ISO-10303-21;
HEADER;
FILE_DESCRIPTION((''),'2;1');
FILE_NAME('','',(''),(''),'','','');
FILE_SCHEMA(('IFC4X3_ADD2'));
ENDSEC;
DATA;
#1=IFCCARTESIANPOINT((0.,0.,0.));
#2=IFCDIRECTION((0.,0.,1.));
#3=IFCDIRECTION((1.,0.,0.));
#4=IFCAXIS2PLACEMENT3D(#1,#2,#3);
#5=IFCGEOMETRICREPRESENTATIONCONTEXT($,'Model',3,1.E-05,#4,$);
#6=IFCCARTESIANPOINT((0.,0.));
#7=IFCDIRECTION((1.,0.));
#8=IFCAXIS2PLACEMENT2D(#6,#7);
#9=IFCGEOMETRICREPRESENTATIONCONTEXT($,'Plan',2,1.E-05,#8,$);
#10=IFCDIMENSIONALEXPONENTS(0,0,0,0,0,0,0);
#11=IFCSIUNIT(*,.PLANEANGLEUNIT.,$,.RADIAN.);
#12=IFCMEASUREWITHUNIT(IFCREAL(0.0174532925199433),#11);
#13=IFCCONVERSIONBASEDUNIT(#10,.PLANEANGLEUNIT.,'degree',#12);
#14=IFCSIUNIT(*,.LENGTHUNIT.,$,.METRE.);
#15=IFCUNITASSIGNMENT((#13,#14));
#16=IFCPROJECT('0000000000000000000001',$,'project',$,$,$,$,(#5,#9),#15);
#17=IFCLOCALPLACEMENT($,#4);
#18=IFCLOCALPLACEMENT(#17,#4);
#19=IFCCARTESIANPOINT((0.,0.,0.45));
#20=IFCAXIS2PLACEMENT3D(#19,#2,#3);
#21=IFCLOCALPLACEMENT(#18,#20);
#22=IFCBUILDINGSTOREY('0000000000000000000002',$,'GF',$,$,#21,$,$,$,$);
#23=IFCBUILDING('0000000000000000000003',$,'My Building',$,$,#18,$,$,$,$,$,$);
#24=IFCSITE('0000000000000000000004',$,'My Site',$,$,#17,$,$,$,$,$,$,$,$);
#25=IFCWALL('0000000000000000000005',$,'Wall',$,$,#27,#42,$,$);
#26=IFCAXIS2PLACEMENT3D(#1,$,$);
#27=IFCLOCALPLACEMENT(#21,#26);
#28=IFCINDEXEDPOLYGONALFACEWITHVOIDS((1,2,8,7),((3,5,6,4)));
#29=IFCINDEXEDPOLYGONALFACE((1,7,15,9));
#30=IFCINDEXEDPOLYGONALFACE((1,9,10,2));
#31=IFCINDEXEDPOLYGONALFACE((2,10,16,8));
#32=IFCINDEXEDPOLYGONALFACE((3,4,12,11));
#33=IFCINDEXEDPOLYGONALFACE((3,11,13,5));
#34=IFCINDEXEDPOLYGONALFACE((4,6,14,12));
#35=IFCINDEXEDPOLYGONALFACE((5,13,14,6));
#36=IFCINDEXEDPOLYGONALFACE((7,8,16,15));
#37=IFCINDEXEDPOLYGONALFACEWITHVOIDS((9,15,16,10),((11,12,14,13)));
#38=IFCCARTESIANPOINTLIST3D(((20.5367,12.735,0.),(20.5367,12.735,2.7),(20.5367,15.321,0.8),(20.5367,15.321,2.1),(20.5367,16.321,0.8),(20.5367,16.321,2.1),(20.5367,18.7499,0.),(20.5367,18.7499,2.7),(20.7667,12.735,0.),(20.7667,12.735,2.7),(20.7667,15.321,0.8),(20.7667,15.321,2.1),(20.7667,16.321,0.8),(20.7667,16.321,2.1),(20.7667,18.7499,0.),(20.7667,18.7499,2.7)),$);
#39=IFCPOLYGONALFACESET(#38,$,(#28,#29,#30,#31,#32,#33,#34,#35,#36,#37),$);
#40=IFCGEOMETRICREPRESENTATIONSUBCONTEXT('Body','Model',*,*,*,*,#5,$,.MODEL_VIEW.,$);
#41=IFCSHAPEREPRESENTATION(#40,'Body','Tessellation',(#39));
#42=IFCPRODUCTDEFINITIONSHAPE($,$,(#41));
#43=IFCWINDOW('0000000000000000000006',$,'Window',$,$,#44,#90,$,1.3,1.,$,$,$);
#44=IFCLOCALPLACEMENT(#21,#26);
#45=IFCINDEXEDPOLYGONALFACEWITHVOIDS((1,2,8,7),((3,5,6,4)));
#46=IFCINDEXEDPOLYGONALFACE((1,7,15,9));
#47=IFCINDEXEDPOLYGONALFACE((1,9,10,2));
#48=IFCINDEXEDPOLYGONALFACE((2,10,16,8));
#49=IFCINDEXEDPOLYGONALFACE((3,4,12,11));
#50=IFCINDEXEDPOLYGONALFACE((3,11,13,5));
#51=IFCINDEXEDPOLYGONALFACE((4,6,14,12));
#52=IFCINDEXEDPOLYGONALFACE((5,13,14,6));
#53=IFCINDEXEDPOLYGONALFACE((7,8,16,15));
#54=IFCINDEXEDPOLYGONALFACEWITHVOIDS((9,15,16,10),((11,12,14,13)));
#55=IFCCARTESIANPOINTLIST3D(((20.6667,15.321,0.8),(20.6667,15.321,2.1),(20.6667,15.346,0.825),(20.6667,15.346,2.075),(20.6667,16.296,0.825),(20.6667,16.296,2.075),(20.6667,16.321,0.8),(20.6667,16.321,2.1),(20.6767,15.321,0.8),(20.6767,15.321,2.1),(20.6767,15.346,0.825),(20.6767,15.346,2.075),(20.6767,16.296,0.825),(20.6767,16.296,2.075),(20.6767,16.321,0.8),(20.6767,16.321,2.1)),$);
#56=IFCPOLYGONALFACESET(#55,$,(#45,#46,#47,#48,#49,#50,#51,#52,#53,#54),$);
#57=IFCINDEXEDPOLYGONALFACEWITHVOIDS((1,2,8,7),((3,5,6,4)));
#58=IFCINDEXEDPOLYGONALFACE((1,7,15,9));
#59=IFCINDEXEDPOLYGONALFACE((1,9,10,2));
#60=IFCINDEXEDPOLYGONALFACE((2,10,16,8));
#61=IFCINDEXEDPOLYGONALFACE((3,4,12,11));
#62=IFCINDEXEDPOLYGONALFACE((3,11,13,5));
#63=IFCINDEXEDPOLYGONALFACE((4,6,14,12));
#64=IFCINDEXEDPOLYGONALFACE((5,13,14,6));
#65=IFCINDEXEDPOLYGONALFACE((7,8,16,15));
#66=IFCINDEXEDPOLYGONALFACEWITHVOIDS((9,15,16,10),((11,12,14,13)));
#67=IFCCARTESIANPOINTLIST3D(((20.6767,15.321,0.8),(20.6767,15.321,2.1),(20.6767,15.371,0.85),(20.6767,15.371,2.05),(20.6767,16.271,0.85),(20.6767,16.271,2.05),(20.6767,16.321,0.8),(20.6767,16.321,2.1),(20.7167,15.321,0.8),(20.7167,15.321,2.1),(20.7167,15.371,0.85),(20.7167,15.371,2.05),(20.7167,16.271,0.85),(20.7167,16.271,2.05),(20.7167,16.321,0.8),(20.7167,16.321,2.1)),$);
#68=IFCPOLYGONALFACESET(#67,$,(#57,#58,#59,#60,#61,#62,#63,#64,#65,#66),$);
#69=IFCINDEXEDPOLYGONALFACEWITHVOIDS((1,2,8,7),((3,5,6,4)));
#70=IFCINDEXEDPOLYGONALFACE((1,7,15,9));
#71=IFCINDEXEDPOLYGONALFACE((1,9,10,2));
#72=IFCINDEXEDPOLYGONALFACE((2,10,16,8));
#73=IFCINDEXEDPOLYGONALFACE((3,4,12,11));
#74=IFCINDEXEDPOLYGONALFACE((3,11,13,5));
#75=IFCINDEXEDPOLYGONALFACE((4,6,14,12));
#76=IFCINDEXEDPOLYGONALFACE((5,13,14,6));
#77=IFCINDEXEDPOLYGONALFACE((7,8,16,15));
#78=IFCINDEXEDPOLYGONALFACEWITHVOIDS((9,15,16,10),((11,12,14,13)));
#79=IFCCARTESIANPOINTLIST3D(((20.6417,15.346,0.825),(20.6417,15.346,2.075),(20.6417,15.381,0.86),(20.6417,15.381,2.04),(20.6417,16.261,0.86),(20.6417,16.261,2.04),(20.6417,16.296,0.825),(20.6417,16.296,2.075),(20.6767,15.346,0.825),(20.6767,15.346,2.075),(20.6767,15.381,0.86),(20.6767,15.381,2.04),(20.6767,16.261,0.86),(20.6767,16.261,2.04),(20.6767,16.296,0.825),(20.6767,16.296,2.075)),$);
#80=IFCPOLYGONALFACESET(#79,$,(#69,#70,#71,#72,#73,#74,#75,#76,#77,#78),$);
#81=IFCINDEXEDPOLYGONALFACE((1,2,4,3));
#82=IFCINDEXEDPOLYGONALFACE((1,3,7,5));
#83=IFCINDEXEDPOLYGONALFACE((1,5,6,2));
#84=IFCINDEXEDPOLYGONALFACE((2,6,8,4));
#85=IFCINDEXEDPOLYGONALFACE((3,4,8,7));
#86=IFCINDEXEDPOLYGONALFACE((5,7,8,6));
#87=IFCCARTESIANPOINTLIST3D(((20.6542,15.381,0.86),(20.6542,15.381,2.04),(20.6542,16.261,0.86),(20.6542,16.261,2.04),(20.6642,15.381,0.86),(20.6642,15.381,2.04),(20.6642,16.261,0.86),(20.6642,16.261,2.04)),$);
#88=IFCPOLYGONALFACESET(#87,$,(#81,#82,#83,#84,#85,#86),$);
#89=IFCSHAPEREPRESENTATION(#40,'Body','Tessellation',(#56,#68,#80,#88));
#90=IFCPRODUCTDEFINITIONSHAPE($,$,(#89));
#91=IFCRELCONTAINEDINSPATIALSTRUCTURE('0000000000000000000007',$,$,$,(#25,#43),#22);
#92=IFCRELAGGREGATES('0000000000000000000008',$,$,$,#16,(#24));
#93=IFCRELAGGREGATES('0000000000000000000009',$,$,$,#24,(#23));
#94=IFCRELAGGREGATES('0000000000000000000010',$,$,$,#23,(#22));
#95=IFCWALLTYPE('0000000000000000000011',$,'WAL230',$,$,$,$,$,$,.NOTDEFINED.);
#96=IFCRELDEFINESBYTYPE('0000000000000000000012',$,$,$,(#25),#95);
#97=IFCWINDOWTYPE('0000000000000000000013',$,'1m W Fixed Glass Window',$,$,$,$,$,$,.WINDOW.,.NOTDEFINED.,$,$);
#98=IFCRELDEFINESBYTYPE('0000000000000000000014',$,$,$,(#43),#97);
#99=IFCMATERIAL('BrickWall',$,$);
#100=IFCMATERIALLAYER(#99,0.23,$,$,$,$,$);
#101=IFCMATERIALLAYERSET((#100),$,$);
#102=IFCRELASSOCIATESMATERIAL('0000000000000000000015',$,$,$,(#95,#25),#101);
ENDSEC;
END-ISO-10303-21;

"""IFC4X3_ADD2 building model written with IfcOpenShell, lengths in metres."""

from ifc_helpers import new_model, entity, si_unit, converted_unit, frame, origin_with_axes, origin_2d_with_axis, place, context, subcontext, project, spatial, line, indexed_curve, outline, extrude, shape, source, transform, mapped, material, layer, layer_set, layer_usage, type_object, type_shapes, element, fill, save


model = new_model("IFC4X3_ADD2")

# Units and contexts
model_context = context("Model", 3, precision=1e-05, world=origin_with_axes())
plan_context = context("Plan", 2, precision=1e-05, world=origin_2d_with_axis())
body_context_1 = subcontext(model_context, "Body", "Model", "MODEL_VIEW")
body_context_2 = subcontext(plan_context, "Body", "Plan", "PLAN_VIEW")
ifc_project = project(units=[converted_unit("PLANEANGLEUNIT", "degree", entity("IfcReal", 0.0174532925199433), si_unit("PLANEANGLEUNIT", "RADIAN"), dimensions=[0, 0, 0, 0, 0, 0, 0]), si_unit("LENGTHUNIT", "METRE")], contexts=[model_context, plan_context])

# Site, building, storey
site_placement = place(None, origin_with_axes())
site = spatial("IfcSite", under=ifc_project, at=site_placement, Name="My Site")
building_placement = place(site_placement, origin_with_axes())
building = spatial("IfcBuilding", under=site, at=building_placement, Name="My Building")
storey_placement = place(building_placement, frame((0.0, 0.0, 0.45), z_axis=(0.0, 0.0, 1.0), x_axis=(1.0, 0.0, 0.0)))
storey = spatial("IfcBuildingStorey", under=building, at=storey_placement, Name="GF")

# Shared definitions
ifc_material_1 = material(Name="BrickWall")
ifc_layer_1 = layer(ifc_material_1, 0.23)
ifc_layer_set_1 = layer_set([ifc_layer_1])
wall_type_1 = type_object("IfcWallType", Name="WAL230", PredefinedType="NOTDEFINED", material=ifc_layer_set_1)

# Wall, opening, window
ifc_layer_usage_1 = layer_usage(ifc_layer_set_1, "AXIS2", "POSITIVE", 0.0)
wall_1_placement = place(storey_placement, frame((20.7667, 12.735, 0.0), z_axis=(0.0, 0.0, 1.0), x_axis=(0.0, 1.0, 0.0)))
wall_1 = element("IfcWall", 1, at=wall_1_placement, inside=storey, type_object=wall_type_1, material=ifc_layer_usage_1, Name="Wall", context=body_context_1, shape_type="SweptSolid", body=[
    extrude(outline(indexed_curve([(0.0, 0.0), (0.0, 0.23), (6.0149, 0.23), (6.0149, 0.0), (0.0, 0.0)], self_intersect=False)), origin_with_axes(), (0.0, 0.0, 1.0), 2.7),
])
shared_shape_1 = source(origin_with_axes(), body_context_1, "Body", "SweptSolid", [
    extrude(outline(indexed_curve([(0.0, 0.0), (1.0, 0.0), (1.0, 1.3), (0.0, 1.3)], segments=[line(1, 2, 3, 4, 1)])), frame((0.0, -0.6, 0.0), z_axis=(0.0, -1.0, 0.0), x_axis=(1.0, 0.0, 0.0)), (0.0, 0.0, -1.0), 1.2),
])
opening_1_placement = place(wall_1_placement, frame((2.586, 0.0, 0.8), z_axis=(0.0, 0.0, 1.0), x_axis=(1.0, 0.0, 0.0)))
opening_1 = element("IfcOpeningElement", 2, at=opening_1_placement, cuts=wall_1, PredefinedType="OPENING", context=body_context_1, shape_type="MappedRepresentation", body=[
    mapped(shared_shape_1, transform((0.0, 0.0, 0.0), x_axis=(1.0, 0.0, 0.0), y_axis=(0.0, 1.0, 0.0), z_axis=(0.0, 0.0, 1.0), scale=1.0)),
])
window_type = type_object("IfcWindowType", Name="1m W Fixed Glass Window", PartitioningType="NOTDEFINED", PredefinedType="WINDOW")
shared_shape_2 = source(origin_with_axes(), body_context_1, "Body", "SweptSolid", [
    extrude(outline(indexed_curve([(0.0, 0.0), (1.0, 0.0), (1.0, 1.3), (0.0, 1.3)], segments=[line(1, 2, 3, 4, 1)]), holes=[indexed_curve([(0.025, 0.025), (0.975, 0.025), (0.975, 1.275), (0.025, 1.275)], segments=[line(1, 2, 3, 4, 1)])]), frame((0.0, 0.09, 0.0), z_axis=(0.0, -1.0, 0.0), x_axis=(1.0, 0.0, 0.0)), (0.0, 0.0, -1.0), 0.01),
    extrude(outline(indexed_curve([(0.0, 0.0), (1.0, 0.0), (1.0, 1.3), (0.0, 1.3)], segments=[line(1, 2, 3, 4, 1)]), holes=[indexed_curve([(0.05, 0.05), (0.95, 0.05), (0.95, 1.25), (0.05, 1.25)], segments=[line(1, 2, 3, 4, 1)])]), frame((0.0, 0.05, 0.0), z_axis=(0.0, -1.0, 0.0), x_axis=(1.0, 0.0, 0.0)), (0.0, 0.0, -1.0), 0.04),
    extrude(outline(indexed_curve([(0.0, 0.0), (0.95, 0.0), (0.95, 1.25), (0.0, 1.25)], segments=[line(1, 2, 3, 4, 1)]), holes=[indexed_curve([(0.035, 0.035), (0.915, 0.035), (0.915, 1.215), (0.035, 1.215)], segments=[line(1, 2, 3, 4, 1)])]), frame((0.025, 0.09, 0.025), z_axis=(0.0, -1.0, 0.0), x_axis=(1.0, 0.0, 0.0)), (0.0, 0.0, -1.0), 0.035),
    extrude(outline(indexed_curve([(0.035, 0.035), (0.915, 0.035), (0.915, 1.215), (0.035, 1.215)], segments=[line(1, 2, 3, 4, 1)])), frame((0.025, 0.1025, 0.025), z_axis=(0.0, -1.0, 0.0), x_axis=(1.0, 0.0, 0.0)), (0.0, 0.0, -1.0), 0.01),
])
shared_shape_3 = source(origin_with_axes(), body_context_2, "Body", "Curve2D", [
    entity("IfcIndexedPolyCurve", entity("IfcCartesianPointList2D", [[0.05, 0.05], [0.95, 0.05]])),
    entity("IfcIndexedPolyCurve", entity("IfcCartesianPointList2D", [[0.0, 0.1], [0.025, 0.1], [0.025, 0.09], [0.05, 0.09], [0.05, 0.05], [0.0, 0.05]]), [entity("IfcLineIndex", [1, 2, 3, 4, 5, 6, 1])]),
    entity("IfcIndexedPolyCurve", entity("IfcCartesianPointList2D", [[1.0, 0.1], [0.975, 0.1], [0.975, 0.09], [0.95, 0.09], [0.95, 0.05], [1.0, 0.05]]), [entity("IfcLineIndex", [1, 2, 3, 4, 5, 6, 1])]),
    entity("IfcIndexedPolyCurve", entity("IfcCartesianPointList2D", [[0.025, 0.09], [0.06, 0.09], [0.06, 0.125], [0.025, 0.125]]), [entity("IfcLineIndex", [1, 2, 3, 4, 1])]),
    entity("IfcIndexedPolyCurve", entity("IfcCartesianPointList2D", [[0.975, 0.09], [0.94, 0.09], [0.94, 0.125], [0.975, 0.125]]), [entity("IfcLineIndex", [1, 2, 3, 4, 1])]),
    entity("IfcIndexedPolyCurve", entity("IfcCartesianPointList2D", [[0.06, 0.09], [0.94, 0.09]])),
    entity("IfcIndexedPolyCurve", entity("IfcCartesianPointList2D", [[0.06, 0.125], [0.94, 0.125]])),
    entity("IfcIndexedPolyCurve", entity("IfcCartesianPointList2D", [[0.06, 0.1075], [0.94, 0.1075]])),
])
type_shapes(window_type, [shared_shape_2, shared_shape_3])
placement_1 = place(storey_placement, frame((20.7667, 0.23, 0.0), z_axis=(0.0, 0.0, 1.0), x_axis=(0.0, 1.0, 0.0)))
placement_2 = place(placement_1, frame((15.091, 0.0, 0.8), z_axis=(0.0, 0.0, 1.0), x_axis=(1.0, 0.0, 0.0)))
window_placement = place(placement_2, origin_with_axes())
window = element("IfcWindow", 3, at=window_placement, inside=storey, type_object=window_type, Name="Window", OverallHeight=1.3, OverallWidth=1.0, shapes=[
    shape(body_context_1, "Body", "MappedRepresentation", [mapped(shared_shape_2, transform((0.0, 0.0, 0.0), x_axis=(1.0, 0.0, 0.0), y_axis=(0.0, 1.0, 0.0), z_axis=(0.0, 0.0, 1.0), scale=1.0))]),
    shape(body_context_2, "Body", "MappedRepresentation", [mapped(shared_shape_3, transform((0.0, 0.0, 0.0), x_axis=(1.0, 0.0, 0.0), y_axis=(0.0, 1.0, 0.0), z_axis=(0.0, 0.0, 1.0), scale=1.0))]),
])
fill(opening_1, window)

save(model, "model.ifc")
